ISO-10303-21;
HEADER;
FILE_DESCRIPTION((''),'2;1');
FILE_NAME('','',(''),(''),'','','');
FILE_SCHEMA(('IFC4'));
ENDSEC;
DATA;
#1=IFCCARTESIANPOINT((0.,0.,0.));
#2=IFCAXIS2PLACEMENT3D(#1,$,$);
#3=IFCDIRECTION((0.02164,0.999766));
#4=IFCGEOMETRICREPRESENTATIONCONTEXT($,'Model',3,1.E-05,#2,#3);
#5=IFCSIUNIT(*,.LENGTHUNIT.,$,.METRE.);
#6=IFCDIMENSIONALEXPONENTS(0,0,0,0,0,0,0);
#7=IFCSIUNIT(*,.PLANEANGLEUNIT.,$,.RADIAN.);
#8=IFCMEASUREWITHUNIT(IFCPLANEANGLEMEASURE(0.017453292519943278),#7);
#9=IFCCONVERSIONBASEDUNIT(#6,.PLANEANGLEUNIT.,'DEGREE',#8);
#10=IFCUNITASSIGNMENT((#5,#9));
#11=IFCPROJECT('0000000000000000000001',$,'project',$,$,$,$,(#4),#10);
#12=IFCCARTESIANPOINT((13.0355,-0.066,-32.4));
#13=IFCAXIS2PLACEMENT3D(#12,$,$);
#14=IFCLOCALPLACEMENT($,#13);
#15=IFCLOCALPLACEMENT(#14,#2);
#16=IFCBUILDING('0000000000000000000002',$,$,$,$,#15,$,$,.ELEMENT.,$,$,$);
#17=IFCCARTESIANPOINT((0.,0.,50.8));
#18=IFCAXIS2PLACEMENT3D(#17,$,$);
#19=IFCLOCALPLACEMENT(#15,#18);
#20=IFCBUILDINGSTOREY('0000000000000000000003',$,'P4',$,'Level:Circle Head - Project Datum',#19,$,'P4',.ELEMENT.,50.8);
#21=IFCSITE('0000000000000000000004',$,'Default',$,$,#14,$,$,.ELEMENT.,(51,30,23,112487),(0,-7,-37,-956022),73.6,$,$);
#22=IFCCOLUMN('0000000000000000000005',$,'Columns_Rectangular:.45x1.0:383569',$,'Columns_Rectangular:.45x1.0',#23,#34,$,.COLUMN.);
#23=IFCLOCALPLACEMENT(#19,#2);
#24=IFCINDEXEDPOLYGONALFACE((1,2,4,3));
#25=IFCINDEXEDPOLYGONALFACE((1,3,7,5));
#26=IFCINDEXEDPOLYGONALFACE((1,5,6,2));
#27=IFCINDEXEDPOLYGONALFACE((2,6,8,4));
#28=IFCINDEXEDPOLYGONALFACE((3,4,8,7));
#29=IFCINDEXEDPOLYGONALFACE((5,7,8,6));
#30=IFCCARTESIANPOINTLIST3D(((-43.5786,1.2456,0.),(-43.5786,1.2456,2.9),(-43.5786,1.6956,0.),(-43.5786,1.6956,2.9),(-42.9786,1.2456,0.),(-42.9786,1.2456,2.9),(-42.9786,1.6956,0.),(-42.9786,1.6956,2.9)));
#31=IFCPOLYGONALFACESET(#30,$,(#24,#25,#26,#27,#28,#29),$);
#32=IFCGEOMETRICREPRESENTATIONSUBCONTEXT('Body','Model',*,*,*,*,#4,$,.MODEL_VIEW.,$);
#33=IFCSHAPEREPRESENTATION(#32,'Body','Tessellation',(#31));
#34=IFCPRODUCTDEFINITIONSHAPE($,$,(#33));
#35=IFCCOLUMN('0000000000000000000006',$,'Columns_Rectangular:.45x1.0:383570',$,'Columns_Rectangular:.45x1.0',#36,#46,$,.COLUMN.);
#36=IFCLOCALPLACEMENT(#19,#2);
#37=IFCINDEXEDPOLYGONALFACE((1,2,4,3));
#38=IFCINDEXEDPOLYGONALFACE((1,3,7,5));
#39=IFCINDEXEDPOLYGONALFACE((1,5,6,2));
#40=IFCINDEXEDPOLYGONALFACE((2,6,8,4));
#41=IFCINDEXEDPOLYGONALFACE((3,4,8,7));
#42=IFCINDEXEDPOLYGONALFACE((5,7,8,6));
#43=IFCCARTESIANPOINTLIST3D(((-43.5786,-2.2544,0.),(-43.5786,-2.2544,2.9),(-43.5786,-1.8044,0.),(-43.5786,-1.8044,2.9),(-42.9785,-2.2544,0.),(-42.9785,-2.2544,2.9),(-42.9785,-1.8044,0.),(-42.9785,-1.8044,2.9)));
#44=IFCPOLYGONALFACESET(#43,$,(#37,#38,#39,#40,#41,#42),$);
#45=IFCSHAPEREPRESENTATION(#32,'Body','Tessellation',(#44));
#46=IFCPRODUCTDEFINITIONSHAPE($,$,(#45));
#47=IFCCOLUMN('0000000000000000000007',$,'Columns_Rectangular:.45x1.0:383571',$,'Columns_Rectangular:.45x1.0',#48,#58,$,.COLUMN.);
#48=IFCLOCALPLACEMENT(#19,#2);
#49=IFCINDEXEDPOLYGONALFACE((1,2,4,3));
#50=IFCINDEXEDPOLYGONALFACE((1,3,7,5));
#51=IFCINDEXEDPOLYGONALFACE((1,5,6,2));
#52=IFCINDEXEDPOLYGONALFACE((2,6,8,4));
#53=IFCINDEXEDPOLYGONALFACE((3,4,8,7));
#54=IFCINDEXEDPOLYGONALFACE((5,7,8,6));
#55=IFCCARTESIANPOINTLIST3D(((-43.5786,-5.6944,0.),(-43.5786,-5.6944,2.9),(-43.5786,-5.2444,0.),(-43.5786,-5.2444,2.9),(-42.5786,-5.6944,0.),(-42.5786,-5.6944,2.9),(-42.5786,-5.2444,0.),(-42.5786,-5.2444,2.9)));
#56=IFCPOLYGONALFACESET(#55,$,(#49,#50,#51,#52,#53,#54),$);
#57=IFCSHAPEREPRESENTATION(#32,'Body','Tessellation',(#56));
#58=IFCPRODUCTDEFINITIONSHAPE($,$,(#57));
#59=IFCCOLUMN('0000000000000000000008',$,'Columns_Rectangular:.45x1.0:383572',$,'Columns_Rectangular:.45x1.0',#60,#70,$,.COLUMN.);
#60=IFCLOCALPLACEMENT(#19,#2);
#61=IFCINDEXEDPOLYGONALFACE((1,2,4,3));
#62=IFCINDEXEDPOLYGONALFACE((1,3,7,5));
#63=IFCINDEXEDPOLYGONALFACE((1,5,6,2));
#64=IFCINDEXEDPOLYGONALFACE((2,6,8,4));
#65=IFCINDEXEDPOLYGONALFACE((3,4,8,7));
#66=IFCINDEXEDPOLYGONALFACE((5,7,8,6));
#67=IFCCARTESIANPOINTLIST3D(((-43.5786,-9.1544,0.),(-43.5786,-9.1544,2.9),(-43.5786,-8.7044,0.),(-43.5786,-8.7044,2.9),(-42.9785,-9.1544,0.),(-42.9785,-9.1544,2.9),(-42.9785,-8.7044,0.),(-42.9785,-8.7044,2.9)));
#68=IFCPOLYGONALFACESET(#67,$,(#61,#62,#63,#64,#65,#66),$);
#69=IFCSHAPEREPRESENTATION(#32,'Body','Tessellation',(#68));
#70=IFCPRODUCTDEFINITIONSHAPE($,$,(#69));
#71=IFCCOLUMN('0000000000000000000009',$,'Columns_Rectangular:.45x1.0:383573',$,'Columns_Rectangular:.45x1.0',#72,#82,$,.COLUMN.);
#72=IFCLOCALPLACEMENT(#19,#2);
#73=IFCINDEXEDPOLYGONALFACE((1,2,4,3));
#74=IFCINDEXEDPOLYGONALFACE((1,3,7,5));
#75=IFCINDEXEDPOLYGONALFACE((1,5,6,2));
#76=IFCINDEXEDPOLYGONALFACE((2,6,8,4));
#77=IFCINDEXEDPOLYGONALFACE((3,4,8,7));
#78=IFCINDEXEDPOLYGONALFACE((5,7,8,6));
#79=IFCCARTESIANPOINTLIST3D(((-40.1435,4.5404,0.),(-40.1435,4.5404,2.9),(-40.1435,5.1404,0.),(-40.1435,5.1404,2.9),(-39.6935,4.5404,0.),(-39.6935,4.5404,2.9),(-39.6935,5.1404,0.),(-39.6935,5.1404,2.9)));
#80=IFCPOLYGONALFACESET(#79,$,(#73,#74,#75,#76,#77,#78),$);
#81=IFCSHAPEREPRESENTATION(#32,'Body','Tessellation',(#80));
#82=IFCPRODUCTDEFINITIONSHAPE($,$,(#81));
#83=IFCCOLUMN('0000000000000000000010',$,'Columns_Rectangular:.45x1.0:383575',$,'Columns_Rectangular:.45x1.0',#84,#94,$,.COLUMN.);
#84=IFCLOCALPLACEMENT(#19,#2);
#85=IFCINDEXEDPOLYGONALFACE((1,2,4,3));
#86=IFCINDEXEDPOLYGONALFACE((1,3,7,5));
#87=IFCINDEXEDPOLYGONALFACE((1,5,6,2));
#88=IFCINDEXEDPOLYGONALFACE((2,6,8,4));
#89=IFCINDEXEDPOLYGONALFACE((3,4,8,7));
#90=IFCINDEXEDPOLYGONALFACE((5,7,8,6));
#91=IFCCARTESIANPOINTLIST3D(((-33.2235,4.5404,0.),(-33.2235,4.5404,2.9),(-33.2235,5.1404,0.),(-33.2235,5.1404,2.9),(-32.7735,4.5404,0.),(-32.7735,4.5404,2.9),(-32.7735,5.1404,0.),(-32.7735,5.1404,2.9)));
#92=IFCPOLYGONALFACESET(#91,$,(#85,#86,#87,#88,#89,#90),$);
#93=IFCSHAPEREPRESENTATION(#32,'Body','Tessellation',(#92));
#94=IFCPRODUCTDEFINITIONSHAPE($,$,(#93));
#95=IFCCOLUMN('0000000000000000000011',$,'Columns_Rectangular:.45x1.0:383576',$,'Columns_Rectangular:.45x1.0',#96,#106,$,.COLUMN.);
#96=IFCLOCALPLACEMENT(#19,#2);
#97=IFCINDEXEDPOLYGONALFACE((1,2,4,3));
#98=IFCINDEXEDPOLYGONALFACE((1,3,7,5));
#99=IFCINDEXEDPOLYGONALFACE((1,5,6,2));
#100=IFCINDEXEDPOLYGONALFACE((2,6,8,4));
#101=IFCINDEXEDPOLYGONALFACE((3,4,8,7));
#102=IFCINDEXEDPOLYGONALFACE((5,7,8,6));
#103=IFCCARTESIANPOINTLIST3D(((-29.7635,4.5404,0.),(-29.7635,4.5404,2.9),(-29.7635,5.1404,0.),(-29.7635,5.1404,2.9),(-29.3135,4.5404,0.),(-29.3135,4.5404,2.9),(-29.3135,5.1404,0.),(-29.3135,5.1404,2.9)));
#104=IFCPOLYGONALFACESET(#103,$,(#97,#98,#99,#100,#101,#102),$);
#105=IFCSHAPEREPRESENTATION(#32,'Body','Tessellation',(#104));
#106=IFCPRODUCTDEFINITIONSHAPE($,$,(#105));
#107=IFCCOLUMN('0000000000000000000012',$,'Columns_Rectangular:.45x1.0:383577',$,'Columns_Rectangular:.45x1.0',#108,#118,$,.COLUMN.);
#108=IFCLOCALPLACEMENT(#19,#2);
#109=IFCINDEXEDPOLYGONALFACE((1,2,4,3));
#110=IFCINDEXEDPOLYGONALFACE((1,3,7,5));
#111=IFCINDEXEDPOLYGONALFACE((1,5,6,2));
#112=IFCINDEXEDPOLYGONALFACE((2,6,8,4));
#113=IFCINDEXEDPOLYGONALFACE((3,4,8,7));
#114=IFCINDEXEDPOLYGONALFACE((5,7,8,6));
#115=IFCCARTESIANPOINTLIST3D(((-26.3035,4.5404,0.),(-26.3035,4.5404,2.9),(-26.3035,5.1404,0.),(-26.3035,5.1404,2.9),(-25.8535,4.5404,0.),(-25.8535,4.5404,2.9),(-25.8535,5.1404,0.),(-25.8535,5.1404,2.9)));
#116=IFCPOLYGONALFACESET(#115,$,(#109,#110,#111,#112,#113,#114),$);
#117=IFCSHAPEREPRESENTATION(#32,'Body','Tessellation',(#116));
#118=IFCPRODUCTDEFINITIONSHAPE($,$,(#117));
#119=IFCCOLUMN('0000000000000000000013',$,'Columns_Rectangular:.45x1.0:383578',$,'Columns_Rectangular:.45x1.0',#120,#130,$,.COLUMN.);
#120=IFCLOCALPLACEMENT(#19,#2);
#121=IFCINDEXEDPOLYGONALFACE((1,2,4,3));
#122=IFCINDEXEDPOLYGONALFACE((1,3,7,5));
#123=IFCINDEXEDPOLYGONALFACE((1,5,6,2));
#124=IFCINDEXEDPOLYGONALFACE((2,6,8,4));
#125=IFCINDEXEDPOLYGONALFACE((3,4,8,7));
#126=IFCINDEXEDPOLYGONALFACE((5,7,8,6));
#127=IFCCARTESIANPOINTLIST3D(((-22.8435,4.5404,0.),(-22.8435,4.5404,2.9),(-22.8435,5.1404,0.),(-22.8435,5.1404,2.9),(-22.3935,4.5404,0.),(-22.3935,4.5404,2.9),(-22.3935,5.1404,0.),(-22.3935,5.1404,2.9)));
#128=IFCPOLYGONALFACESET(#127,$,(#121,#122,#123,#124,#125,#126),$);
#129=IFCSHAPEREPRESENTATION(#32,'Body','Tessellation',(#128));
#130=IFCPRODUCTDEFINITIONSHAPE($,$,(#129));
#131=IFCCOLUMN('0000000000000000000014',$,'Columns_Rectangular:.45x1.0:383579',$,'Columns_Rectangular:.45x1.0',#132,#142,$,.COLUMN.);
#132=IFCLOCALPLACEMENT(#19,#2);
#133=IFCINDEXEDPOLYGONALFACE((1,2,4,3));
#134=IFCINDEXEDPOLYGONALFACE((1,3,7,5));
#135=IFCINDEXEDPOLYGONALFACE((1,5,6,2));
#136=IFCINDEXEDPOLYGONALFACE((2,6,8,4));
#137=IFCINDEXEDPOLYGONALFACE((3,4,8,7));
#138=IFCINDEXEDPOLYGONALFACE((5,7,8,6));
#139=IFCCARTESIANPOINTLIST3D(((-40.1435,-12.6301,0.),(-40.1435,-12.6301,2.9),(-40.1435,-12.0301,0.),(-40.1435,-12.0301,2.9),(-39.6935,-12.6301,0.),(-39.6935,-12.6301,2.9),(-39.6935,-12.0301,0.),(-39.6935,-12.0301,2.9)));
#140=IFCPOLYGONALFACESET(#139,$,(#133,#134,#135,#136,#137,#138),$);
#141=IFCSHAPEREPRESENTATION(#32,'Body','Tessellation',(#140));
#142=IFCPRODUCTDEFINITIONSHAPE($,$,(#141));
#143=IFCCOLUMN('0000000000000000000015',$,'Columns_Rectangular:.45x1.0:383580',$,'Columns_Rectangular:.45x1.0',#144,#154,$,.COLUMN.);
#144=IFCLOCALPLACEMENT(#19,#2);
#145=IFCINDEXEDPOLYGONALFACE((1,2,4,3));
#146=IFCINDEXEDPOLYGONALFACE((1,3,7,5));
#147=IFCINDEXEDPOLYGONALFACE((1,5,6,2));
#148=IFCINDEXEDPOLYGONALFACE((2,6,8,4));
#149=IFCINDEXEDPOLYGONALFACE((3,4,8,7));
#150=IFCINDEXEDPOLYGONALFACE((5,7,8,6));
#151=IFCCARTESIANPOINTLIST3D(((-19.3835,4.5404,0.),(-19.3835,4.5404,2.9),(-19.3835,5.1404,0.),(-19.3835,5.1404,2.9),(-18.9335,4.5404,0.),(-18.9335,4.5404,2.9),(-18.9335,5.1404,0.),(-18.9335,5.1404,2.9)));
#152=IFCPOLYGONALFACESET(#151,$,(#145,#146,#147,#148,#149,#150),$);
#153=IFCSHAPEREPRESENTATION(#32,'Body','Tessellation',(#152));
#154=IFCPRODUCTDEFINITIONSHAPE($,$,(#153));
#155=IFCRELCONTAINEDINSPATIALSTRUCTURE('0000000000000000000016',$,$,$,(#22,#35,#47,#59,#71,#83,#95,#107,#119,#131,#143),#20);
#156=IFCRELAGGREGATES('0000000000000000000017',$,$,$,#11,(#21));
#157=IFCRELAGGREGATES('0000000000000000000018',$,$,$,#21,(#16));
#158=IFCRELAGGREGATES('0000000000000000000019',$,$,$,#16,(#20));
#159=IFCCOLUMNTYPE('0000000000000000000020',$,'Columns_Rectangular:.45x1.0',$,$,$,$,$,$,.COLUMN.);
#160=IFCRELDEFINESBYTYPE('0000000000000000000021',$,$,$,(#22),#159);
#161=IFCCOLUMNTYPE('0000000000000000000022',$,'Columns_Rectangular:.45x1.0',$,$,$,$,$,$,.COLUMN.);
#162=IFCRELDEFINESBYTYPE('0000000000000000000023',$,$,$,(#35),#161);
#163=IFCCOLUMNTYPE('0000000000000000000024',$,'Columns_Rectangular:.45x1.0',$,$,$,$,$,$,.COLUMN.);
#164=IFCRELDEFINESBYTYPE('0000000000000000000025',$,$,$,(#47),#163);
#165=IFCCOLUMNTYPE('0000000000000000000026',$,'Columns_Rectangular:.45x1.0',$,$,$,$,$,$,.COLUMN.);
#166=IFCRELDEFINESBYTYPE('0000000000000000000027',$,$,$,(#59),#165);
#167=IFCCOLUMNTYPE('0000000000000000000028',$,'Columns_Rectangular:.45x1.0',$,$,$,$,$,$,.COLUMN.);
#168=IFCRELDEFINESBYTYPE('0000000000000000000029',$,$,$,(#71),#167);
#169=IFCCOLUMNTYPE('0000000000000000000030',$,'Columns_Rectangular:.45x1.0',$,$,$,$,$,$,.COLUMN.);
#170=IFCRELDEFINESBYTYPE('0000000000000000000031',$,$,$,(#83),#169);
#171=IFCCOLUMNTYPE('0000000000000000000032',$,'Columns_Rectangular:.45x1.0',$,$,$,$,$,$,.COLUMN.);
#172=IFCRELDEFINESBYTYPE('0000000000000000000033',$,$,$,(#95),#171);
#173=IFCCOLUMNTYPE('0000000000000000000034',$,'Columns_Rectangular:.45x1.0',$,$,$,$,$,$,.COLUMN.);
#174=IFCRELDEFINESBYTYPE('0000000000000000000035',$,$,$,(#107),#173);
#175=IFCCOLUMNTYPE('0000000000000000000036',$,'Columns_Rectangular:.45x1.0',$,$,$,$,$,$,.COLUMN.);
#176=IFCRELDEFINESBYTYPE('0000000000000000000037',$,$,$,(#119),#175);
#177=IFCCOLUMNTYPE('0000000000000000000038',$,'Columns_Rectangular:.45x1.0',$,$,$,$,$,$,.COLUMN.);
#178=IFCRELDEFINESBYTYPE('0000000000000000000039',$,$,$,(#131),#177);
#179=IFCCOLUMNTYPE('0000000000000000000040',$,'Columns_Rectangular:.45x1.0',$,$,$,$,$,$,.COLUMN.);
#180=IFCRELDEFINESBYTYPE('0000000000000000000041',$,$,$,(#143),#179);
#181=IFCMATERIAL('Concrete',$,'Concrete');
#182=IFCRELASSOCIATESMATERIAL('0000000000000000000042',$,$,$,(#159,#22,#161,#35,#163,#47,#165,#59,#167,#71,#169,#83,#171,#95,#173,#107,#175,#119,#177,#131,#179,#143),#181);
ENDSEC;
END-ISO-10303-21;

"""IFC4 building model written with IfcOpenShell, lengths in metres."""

from ifc_helpers import new_model, entity, si_unit, converted_unit, direction, frame, origin, place, context, subcontext, project, spatial, indexed_curve, outline, extrude, source, transform, mapped, material, type_object, type_shapes, element, save


model = new_model("IFC4")

# Units and contexts
model_context = context("Model", 3, precision=1e-05, world=origin(), true_north=direction((0.02164, 0.999766)))
body_context = subcontext(model_context, "Body", "Model", "MODEL_VIEW")
ifc_project = project(units=[si_unit("LENGTHUNIT", "METRE"), converted_unit("PLANEANGLEUNIT", "DEGREE", entity("IfcPlaneAngleMeasure", 0.017453292519943278), si_unit("PLANEANGLEUNIT", "RADIAN"), dimensions=[0, 0, 0, 0, 0, 0, 0])], contexts=[model_context])

# Site, building, storey
site_placement = place(None, frame((13.0355, -0.066, -32.4)))
site = spatial("IfcSite", under=ifc_project, at=site_placement, Name="Default", CompositionType="ELEMENT", RefLatitude=(51, 30, 23, 112487), RefLongitude=(0, -7, -37, -956022), RefElevation=73.6)
building_placement = place(site_placement, origin())
building = spatial("IfcBuilding", under=site, at=building_placement, CompositionType="ELEMENT")
storey_placement = place(building_placement, frame((0.0, 0.0, 50.8)))
storey = spatial("IfcBuildingStorey", under=building, at=storey_placement, Name="P4", ObjectType="Level:Circle Head - Project Datum", LongName="P4", CompositionType="ELEMENT", Elevation=50.8)

# Columns
ifc_material = material(Name="Concrete", Category="Concrete")
column_type_1 = type_object("IfcColumnType", Name="Columns_Rectangular:.45x1.0", PredefinedType="COLUMN", material=ifc_material)
shared_shape_1 = source(origin(), body_context, "Body", "SweptSolid", [
    extrude(outline(indexed_curve([(-0.3, -0.225), (0.3, -0.225), (0.3, 0.225), (-0.3, 0.225), (-0.3, -0.225)], self_intersect=False)), frame((-43.2786, 1.4706, 50.8)), (0.0, 0.0, 1.0), 2.9),
])
type_shapes(column_type_1, [shared_shape_1])
column_1_placement = place(storey_placement, frame((0.0, 0.0, -50.8)))
element("IfcColumn", 1, at=column_1_placement, inside=storey, type_object=column_type_1, material=ifc_material, Name="Columns_Rectangular:.45x1.0:383569", ObjectType="Columns_Rectangular:.45x1.0", PredefinedType="COLUMN", context=body_context, shape_type="MappedRepresentation", body=[
    mapped(shared_shape_1, transform((0.0, 0.0, 0.0), scale=1.0)),
])
column_type_2 = type_object("IfcColumnType", Name="Columns_Rectangular:.45x1.0", PredefinedType="COLUMN", material=ifc_material)
shared_shape_2 = source(origin(), body_context, "Body", "SweptSolid", [
    extrude(outline(indexed_curve([(-0.3, -0.225), (0.3, -0.225), (0.3, 0.225), (-0.3, 0.225), (-0.3, -0.225)], self_intersect=False)), frame((-43.2785, -2.0294, 50.8)), (0.0, 0.0, 1.0), 2.9),
])
type_shapes(column_type_2, [shared_shape_2])
column_2_placement = place(storey_placement, frame((0.0, 0.0, -50.8)))
element("IfcColumn", 2, at=column_2_placement, inside=storey, type_object=column_type_2, material=ifc_material, Name="Columns_Rectangular:.45x1.0:383570", ObjectType="Columns_Rectangular:.45x1.0", PredefinedType="COLUMN", context=body_context, shape_type="MappedRepresentation", body=[
    mapped(shared_shape_2, transform((0.0, 0.0, 0.0), scale=1.0)),
])
column_type_3 = type_object("IfcColumnType", Name="Columns_Rectangular:.45x1.0", PredefinedType="COLUMN", material=ifc_material)
shared_shape_3 = source(origin(), body_context, "Body", "SweptSolid", [
    extrude(outline(indexed_curve([(-0.5, -0.225), (0.5, -0.225), (0.5, 0.225), (-0.5, 0.225), (-0.5, -0.225)], self_intersect=False)), frame((-43.0786, -5.4694, 50.8), z_axis=(0.0, 0.0, 1.0), x_axis=(-1.0, 0.0, 0.0)), (0.0, 0.0, 1.0), 2.9),
])
type_shapes(column_type_3, [shared_shape_3])
column_3_placement = place(storey_placement, frame((0.0, 0.0, -50.8)))
element("IfcColumn", 3, at=column_3_placement, inside=storey, type_object=column_type_3, material=ifc_material, Name="Columns_Rectangular:.45x1.0:383571", ObjectType="Columns_Rectangular:.45x1.0", PredefinedType="COLUMN", context=body_context, shape_type="MappedRepresentation", body=[
    mapped(shared_shape_3, transform((0.0, 0.0, 0.0), scale=1.0)),
])
column_type_4 = type_object("IfcColumnType", Name="Columns_Rectangular:.45x1.0", PredefinedType="COLUMN", material=ifc_material)
shared_shape_4 = source(origin(), body_context, "Body", "SweptSolid", [
    extrude(outline(indexed_curve([(-0.3, -0.225), (0.3, -0.225), (0.3, 0.225), (-0.3, 0.225), (-0.3, -0.225)], self_intersect=False)), frame((-43.2785, -8.9294, 50.8)), (0.0, 0.0, 1.0), 2.9),
])
type_shapes(column_type_4, [shared_shape_4])
column_4_placement = place(storey_placement, frame((0.0, 0.0, -50.8)))
element("IfcColumn", 4, at=column_4_placement, inside=storey, type_object=column_type_4, material=ifc_material, Name="Columns_Rectangular:.45x1.0:383572", ObjectType="Columns_Rectangular:.45x1.0", PredefinedType="COLUMN", context=body_context, shape_type="MappedRepresentation", body=[
    mapped(shared_shape_4, transform((0.0, 0.0, 0.0), scale=1.0)),
])
column_type_5 = type_object("IfcColumnType", Name="Columns_Rectangular:.45x1.0", PredefinedType="COLUMN", material=ifc_material)
shared_shape_5 = source(origin(), body_context, "Body", "SweptSolid", [
    extrude(outline(indexed_curve([(-0.3, -0.225), (0.3, -0.225), (0.3, 0.225), (-0.3, 0.225), (-0.3, -0.225)], self_intersect=False)), frame((-39.9185, 4.8404, 50.8), z_axis=(0.0, 0.0, 1.0), x_axis=(0.0, -1.0, 0.0)), (0.0, 0.0, 1.0), 2.9),
])
type_shapes(column_type_5, [shared_shape_5])
column_5_placement = place(storey_placement, frame((0.0, 0.0, -50.8)))
element("IfcColumn", 5, at=column_5_placement, inside=storey, type_object=column_type_5, material=ifc_material, Name="Columns_Rectangular:.45x1.0:383573", ObjectType="Columns_Rectangular:.45x1.0", PredefinedType="COLUMN", context=body_context, shape_type="MappedRepresentation", body=[
    mapped(shared_shape_5, transform((0.0, 0.0, 0.0), scale=1.0)),
])
column_type_6 = type_object("IfcColumnType", Name="Columns_Rectangular:.45x1.0", PredefinedType="COLUMN", material=ifc_material)
shared_shape_6 = source(origin(), body_context, "Body", "SweptSolid", [
    extrude(outline(indexed_curve([(-0.3, -0.225), (0.3, -0.225), (0.3, 0.225), (-0.3, 0.225), (-0.3, -0.225)], self_intersect=False)), frame((-32.9985, 4.8404, 50.8), z_axis=(0.0, 0.0, 1.0), x_axis=(0.0, -1.0, 0.0)), (0.0, 0.0, 1.0), 2.9),
])
type_shapes(column_type_6, [shared_shape_6])
column_6_placement = place(storey_placement, frame((0.0, 0.0, -50.8)))
element("IfcColumn", 6, at=column_6_placement, inside=storey, type_object=column_type_6, material=ifc_material, Name="Columns_Rectangular:.45x1.0:383575", ObjectType="Columns_Rectangular:.45x1.0", PredefinedType="COLUMN", context=body_context, shape_type="MappedRepresentation", body=[
    mapped(shared_shape_6, transform((0.0, 0.0, 0.0), scale=1.0)),
])
column_type_7 = type_object("IfcColumnType", Name="Columns_Rectangular:.45x1.0", PredefinedType="COLUMN", material=ifc_material)
shared_shape_7 = source(origin(), body_context, "Body", "SweptSolid", [
    extrude(outline(indexed_curve([(-0.3, -0.225), (0.3, -0.225), (0.3, 0.225), (-0.3, 0.225), (-0.3, -0.225)], self_intersect=False)), frame((-29.5385, 4.8404, 50.8), z_axis=(0.0, 0.0, 1.0), x_axis=(0.0, -1.0, 0.0)), (0.0, 0.0, 1.0), 2.9),
])
type_shapes(column_type_7, [shared_shape_7])
column_7_placement = place(storey_placement, frame((0.0, 0.0, -50.8)))
element("IfcColumn", 7, at=column_7_placement, inside=storey, type_object=column_type_7, material=ifc_material, Name="Columns_Rectangular:.45x1.0:383576", ObjectType="Columns_Rectangular:.45x1.0", PredefinedType="COLUMN", context=body_context, shape_type="MappedRepresentation", body=[
    mapped(shared_shape_7, transform((0.0, 0.0, 0.0), scale=1.0)),
])
column_type_8 = type_object("IfcColumnType", Name="Columns_Rectangular:.45x1.0", PredefinedType="COLUMN", material=ifc_material)
shared_shape_8 = source(origin(), body_context, "Body", "SweptSolid", [
    extrude(outline(indexed_curve([(-0.3, -0.225), (0.3, -0.225), (0.3, 0.225), (-0.3, 0.225), (-0.3, -0.225)], self_intersect=False)), frame((-26.0785, 4.8404, 50.8), z_axis=(0.0, 0.0, 1.0), x_axis=(0.0, -1.0, 0.0)), (0.0, 0.0, 1.0), 2.9),
])
type_shapes(column_type_8, [shared_shape_8])
column_8_placement = place(storey_placement, frame((0.0, 0.0, -50.8)))
element("IfcColumn", 8, at=column_8_placement, inside=storey, type_object=column_type_8, material=ifc_material, Name="Columns_Rectangular:.45x1.0:383577", ObjectType="Columns_Rectangular:.45x1.0", PredefinedType="COLUMN", context=body_context, shape_type="MappedRepresentation", body=[
    mapped(shared_shape_8, transform((0.0, 0.0, 0.0), scale=1.0)),
])
column_type_9 = type_object("IfcColumnType", Name="Columns_Rectangular:.45x1.0", PredefinedType="COLUMN", material=ifc_material)
shared_shape_9 = source(origin(), body_context, "Body", "SweptSolid", [
    extrude(outline(indexed_curve([(-0.3, -0.225), (0.3, -0.225), (0.3, 0.225), (-0.3, 0.225), (-0.3, -0.225)], self_intersect=False)), frame((-22.6185, 4.8404, 50.8), z_axis=(0.0, 0.0, 1.0), x_axis=(0.0, -1.0, 0.0)), (0.0, 0.0, 1.0), 2.9),
])
type_shapes(column_type_9, [shared_shape_9])
column_9_placement = place(storey_placement, frame((0.0, 0.0, -50.8)))
element("IfcColumn", 9, at=column_9_placement, inside=storey, type_object=column_type_9, material=ifc_material, Name="Columns_Rectangular:.45x1.0:383578", ObjectType="Columns_Rectangular:.45x1.0", PredefinedType="COLUMN", context=body_context, shape_type="MappedRepresentation", body=[
    mapped(shared_shape_9, transform((0.0, 0.0, 0.0), scale=1.0)),
])
column_type_10 = type_object("IfcColumnType", Name="Columns_Rectangular:.45x1.0", PredefinedType="COLUMN", material=ifc_material)
shared_shape_10 = source(origin(), body_context, "Body", "SweptSolid", [
    extrude(outline(indexed_curve([(-0.3, -0.225), (0.3, -0.225), (0.3, 0.225), (-0.3, 0.225), (-0.3, -0.225)], self_intersect=False)), frame((-39.9185, -12.3301, 50.8), z_axis=(0.0, 0.0, 1.0), x_axis=(0.000011, 1.0, 0.0)), (0.0, 0.0, 1.0), 2.9),
])
type_shapes(column_type_10, [shared_shape_10])
column_10_placement = place(storey_placement, frame((0.0, 0.0, -50.8)))
element("IfcColumn", 10, at=column_10_placement, inside=storey, type_object=column_type_10, material=ifc_material, Name="Columns_Rectangular:.45x1.0:383579", ObjectType="Columns_Rectangular:.45x1.0", PredefinedType="COLUMN", context=body_context, shape_type="MappedRepresentation", body=[
    mapped(shared_shape_10, transform((0.0, 0.0, 0.0), scale=1.0)),
])
column_type_11 = type_object("IfcColumnType", Name="Columns_Rectangular:.45x1.0", PredefinedType="COLUMN", material=ifc_material)
shared_shape_11 = source(origin(), body_context, "Body", "SweptSolid", [
    extrude(outline(indexed_curve([(-0.3, -0.225), (0.3, -0.225), (0.3, 0.225), (-0.3, 0.225), (-0.3, -0.225)], self_intersect=False)), frame((-19.1585, 4.8404, 50.8), z_axis=(0.0, 0.0, 1.0), x_axis=(0.0, -1.0, 0.0)), (0.0, 0.0, 1.0), 2.9),
])
type_shapes(column_type_11, [shared_shape_11])
column_11_placement = place(storey_placement, frame((0.0, 0.0, -50.8)))
element("IfcColumn", 11, at=column_11_placement, inside=storey, type_object=column_type_11, material=ifc_material, Name="Columns_Rectangular:.45x1.0:383580", ObjectType="Columns_Rectangular:.45x1.0", PredefinedType="COLUMN", context=body_context, shape_type="MappedRepresentation", body=[
    mapped(shared_shape_11, transform((0.0, 0.0, 0.0), scale=1.0)),
])

save(model, "model.ifc")
